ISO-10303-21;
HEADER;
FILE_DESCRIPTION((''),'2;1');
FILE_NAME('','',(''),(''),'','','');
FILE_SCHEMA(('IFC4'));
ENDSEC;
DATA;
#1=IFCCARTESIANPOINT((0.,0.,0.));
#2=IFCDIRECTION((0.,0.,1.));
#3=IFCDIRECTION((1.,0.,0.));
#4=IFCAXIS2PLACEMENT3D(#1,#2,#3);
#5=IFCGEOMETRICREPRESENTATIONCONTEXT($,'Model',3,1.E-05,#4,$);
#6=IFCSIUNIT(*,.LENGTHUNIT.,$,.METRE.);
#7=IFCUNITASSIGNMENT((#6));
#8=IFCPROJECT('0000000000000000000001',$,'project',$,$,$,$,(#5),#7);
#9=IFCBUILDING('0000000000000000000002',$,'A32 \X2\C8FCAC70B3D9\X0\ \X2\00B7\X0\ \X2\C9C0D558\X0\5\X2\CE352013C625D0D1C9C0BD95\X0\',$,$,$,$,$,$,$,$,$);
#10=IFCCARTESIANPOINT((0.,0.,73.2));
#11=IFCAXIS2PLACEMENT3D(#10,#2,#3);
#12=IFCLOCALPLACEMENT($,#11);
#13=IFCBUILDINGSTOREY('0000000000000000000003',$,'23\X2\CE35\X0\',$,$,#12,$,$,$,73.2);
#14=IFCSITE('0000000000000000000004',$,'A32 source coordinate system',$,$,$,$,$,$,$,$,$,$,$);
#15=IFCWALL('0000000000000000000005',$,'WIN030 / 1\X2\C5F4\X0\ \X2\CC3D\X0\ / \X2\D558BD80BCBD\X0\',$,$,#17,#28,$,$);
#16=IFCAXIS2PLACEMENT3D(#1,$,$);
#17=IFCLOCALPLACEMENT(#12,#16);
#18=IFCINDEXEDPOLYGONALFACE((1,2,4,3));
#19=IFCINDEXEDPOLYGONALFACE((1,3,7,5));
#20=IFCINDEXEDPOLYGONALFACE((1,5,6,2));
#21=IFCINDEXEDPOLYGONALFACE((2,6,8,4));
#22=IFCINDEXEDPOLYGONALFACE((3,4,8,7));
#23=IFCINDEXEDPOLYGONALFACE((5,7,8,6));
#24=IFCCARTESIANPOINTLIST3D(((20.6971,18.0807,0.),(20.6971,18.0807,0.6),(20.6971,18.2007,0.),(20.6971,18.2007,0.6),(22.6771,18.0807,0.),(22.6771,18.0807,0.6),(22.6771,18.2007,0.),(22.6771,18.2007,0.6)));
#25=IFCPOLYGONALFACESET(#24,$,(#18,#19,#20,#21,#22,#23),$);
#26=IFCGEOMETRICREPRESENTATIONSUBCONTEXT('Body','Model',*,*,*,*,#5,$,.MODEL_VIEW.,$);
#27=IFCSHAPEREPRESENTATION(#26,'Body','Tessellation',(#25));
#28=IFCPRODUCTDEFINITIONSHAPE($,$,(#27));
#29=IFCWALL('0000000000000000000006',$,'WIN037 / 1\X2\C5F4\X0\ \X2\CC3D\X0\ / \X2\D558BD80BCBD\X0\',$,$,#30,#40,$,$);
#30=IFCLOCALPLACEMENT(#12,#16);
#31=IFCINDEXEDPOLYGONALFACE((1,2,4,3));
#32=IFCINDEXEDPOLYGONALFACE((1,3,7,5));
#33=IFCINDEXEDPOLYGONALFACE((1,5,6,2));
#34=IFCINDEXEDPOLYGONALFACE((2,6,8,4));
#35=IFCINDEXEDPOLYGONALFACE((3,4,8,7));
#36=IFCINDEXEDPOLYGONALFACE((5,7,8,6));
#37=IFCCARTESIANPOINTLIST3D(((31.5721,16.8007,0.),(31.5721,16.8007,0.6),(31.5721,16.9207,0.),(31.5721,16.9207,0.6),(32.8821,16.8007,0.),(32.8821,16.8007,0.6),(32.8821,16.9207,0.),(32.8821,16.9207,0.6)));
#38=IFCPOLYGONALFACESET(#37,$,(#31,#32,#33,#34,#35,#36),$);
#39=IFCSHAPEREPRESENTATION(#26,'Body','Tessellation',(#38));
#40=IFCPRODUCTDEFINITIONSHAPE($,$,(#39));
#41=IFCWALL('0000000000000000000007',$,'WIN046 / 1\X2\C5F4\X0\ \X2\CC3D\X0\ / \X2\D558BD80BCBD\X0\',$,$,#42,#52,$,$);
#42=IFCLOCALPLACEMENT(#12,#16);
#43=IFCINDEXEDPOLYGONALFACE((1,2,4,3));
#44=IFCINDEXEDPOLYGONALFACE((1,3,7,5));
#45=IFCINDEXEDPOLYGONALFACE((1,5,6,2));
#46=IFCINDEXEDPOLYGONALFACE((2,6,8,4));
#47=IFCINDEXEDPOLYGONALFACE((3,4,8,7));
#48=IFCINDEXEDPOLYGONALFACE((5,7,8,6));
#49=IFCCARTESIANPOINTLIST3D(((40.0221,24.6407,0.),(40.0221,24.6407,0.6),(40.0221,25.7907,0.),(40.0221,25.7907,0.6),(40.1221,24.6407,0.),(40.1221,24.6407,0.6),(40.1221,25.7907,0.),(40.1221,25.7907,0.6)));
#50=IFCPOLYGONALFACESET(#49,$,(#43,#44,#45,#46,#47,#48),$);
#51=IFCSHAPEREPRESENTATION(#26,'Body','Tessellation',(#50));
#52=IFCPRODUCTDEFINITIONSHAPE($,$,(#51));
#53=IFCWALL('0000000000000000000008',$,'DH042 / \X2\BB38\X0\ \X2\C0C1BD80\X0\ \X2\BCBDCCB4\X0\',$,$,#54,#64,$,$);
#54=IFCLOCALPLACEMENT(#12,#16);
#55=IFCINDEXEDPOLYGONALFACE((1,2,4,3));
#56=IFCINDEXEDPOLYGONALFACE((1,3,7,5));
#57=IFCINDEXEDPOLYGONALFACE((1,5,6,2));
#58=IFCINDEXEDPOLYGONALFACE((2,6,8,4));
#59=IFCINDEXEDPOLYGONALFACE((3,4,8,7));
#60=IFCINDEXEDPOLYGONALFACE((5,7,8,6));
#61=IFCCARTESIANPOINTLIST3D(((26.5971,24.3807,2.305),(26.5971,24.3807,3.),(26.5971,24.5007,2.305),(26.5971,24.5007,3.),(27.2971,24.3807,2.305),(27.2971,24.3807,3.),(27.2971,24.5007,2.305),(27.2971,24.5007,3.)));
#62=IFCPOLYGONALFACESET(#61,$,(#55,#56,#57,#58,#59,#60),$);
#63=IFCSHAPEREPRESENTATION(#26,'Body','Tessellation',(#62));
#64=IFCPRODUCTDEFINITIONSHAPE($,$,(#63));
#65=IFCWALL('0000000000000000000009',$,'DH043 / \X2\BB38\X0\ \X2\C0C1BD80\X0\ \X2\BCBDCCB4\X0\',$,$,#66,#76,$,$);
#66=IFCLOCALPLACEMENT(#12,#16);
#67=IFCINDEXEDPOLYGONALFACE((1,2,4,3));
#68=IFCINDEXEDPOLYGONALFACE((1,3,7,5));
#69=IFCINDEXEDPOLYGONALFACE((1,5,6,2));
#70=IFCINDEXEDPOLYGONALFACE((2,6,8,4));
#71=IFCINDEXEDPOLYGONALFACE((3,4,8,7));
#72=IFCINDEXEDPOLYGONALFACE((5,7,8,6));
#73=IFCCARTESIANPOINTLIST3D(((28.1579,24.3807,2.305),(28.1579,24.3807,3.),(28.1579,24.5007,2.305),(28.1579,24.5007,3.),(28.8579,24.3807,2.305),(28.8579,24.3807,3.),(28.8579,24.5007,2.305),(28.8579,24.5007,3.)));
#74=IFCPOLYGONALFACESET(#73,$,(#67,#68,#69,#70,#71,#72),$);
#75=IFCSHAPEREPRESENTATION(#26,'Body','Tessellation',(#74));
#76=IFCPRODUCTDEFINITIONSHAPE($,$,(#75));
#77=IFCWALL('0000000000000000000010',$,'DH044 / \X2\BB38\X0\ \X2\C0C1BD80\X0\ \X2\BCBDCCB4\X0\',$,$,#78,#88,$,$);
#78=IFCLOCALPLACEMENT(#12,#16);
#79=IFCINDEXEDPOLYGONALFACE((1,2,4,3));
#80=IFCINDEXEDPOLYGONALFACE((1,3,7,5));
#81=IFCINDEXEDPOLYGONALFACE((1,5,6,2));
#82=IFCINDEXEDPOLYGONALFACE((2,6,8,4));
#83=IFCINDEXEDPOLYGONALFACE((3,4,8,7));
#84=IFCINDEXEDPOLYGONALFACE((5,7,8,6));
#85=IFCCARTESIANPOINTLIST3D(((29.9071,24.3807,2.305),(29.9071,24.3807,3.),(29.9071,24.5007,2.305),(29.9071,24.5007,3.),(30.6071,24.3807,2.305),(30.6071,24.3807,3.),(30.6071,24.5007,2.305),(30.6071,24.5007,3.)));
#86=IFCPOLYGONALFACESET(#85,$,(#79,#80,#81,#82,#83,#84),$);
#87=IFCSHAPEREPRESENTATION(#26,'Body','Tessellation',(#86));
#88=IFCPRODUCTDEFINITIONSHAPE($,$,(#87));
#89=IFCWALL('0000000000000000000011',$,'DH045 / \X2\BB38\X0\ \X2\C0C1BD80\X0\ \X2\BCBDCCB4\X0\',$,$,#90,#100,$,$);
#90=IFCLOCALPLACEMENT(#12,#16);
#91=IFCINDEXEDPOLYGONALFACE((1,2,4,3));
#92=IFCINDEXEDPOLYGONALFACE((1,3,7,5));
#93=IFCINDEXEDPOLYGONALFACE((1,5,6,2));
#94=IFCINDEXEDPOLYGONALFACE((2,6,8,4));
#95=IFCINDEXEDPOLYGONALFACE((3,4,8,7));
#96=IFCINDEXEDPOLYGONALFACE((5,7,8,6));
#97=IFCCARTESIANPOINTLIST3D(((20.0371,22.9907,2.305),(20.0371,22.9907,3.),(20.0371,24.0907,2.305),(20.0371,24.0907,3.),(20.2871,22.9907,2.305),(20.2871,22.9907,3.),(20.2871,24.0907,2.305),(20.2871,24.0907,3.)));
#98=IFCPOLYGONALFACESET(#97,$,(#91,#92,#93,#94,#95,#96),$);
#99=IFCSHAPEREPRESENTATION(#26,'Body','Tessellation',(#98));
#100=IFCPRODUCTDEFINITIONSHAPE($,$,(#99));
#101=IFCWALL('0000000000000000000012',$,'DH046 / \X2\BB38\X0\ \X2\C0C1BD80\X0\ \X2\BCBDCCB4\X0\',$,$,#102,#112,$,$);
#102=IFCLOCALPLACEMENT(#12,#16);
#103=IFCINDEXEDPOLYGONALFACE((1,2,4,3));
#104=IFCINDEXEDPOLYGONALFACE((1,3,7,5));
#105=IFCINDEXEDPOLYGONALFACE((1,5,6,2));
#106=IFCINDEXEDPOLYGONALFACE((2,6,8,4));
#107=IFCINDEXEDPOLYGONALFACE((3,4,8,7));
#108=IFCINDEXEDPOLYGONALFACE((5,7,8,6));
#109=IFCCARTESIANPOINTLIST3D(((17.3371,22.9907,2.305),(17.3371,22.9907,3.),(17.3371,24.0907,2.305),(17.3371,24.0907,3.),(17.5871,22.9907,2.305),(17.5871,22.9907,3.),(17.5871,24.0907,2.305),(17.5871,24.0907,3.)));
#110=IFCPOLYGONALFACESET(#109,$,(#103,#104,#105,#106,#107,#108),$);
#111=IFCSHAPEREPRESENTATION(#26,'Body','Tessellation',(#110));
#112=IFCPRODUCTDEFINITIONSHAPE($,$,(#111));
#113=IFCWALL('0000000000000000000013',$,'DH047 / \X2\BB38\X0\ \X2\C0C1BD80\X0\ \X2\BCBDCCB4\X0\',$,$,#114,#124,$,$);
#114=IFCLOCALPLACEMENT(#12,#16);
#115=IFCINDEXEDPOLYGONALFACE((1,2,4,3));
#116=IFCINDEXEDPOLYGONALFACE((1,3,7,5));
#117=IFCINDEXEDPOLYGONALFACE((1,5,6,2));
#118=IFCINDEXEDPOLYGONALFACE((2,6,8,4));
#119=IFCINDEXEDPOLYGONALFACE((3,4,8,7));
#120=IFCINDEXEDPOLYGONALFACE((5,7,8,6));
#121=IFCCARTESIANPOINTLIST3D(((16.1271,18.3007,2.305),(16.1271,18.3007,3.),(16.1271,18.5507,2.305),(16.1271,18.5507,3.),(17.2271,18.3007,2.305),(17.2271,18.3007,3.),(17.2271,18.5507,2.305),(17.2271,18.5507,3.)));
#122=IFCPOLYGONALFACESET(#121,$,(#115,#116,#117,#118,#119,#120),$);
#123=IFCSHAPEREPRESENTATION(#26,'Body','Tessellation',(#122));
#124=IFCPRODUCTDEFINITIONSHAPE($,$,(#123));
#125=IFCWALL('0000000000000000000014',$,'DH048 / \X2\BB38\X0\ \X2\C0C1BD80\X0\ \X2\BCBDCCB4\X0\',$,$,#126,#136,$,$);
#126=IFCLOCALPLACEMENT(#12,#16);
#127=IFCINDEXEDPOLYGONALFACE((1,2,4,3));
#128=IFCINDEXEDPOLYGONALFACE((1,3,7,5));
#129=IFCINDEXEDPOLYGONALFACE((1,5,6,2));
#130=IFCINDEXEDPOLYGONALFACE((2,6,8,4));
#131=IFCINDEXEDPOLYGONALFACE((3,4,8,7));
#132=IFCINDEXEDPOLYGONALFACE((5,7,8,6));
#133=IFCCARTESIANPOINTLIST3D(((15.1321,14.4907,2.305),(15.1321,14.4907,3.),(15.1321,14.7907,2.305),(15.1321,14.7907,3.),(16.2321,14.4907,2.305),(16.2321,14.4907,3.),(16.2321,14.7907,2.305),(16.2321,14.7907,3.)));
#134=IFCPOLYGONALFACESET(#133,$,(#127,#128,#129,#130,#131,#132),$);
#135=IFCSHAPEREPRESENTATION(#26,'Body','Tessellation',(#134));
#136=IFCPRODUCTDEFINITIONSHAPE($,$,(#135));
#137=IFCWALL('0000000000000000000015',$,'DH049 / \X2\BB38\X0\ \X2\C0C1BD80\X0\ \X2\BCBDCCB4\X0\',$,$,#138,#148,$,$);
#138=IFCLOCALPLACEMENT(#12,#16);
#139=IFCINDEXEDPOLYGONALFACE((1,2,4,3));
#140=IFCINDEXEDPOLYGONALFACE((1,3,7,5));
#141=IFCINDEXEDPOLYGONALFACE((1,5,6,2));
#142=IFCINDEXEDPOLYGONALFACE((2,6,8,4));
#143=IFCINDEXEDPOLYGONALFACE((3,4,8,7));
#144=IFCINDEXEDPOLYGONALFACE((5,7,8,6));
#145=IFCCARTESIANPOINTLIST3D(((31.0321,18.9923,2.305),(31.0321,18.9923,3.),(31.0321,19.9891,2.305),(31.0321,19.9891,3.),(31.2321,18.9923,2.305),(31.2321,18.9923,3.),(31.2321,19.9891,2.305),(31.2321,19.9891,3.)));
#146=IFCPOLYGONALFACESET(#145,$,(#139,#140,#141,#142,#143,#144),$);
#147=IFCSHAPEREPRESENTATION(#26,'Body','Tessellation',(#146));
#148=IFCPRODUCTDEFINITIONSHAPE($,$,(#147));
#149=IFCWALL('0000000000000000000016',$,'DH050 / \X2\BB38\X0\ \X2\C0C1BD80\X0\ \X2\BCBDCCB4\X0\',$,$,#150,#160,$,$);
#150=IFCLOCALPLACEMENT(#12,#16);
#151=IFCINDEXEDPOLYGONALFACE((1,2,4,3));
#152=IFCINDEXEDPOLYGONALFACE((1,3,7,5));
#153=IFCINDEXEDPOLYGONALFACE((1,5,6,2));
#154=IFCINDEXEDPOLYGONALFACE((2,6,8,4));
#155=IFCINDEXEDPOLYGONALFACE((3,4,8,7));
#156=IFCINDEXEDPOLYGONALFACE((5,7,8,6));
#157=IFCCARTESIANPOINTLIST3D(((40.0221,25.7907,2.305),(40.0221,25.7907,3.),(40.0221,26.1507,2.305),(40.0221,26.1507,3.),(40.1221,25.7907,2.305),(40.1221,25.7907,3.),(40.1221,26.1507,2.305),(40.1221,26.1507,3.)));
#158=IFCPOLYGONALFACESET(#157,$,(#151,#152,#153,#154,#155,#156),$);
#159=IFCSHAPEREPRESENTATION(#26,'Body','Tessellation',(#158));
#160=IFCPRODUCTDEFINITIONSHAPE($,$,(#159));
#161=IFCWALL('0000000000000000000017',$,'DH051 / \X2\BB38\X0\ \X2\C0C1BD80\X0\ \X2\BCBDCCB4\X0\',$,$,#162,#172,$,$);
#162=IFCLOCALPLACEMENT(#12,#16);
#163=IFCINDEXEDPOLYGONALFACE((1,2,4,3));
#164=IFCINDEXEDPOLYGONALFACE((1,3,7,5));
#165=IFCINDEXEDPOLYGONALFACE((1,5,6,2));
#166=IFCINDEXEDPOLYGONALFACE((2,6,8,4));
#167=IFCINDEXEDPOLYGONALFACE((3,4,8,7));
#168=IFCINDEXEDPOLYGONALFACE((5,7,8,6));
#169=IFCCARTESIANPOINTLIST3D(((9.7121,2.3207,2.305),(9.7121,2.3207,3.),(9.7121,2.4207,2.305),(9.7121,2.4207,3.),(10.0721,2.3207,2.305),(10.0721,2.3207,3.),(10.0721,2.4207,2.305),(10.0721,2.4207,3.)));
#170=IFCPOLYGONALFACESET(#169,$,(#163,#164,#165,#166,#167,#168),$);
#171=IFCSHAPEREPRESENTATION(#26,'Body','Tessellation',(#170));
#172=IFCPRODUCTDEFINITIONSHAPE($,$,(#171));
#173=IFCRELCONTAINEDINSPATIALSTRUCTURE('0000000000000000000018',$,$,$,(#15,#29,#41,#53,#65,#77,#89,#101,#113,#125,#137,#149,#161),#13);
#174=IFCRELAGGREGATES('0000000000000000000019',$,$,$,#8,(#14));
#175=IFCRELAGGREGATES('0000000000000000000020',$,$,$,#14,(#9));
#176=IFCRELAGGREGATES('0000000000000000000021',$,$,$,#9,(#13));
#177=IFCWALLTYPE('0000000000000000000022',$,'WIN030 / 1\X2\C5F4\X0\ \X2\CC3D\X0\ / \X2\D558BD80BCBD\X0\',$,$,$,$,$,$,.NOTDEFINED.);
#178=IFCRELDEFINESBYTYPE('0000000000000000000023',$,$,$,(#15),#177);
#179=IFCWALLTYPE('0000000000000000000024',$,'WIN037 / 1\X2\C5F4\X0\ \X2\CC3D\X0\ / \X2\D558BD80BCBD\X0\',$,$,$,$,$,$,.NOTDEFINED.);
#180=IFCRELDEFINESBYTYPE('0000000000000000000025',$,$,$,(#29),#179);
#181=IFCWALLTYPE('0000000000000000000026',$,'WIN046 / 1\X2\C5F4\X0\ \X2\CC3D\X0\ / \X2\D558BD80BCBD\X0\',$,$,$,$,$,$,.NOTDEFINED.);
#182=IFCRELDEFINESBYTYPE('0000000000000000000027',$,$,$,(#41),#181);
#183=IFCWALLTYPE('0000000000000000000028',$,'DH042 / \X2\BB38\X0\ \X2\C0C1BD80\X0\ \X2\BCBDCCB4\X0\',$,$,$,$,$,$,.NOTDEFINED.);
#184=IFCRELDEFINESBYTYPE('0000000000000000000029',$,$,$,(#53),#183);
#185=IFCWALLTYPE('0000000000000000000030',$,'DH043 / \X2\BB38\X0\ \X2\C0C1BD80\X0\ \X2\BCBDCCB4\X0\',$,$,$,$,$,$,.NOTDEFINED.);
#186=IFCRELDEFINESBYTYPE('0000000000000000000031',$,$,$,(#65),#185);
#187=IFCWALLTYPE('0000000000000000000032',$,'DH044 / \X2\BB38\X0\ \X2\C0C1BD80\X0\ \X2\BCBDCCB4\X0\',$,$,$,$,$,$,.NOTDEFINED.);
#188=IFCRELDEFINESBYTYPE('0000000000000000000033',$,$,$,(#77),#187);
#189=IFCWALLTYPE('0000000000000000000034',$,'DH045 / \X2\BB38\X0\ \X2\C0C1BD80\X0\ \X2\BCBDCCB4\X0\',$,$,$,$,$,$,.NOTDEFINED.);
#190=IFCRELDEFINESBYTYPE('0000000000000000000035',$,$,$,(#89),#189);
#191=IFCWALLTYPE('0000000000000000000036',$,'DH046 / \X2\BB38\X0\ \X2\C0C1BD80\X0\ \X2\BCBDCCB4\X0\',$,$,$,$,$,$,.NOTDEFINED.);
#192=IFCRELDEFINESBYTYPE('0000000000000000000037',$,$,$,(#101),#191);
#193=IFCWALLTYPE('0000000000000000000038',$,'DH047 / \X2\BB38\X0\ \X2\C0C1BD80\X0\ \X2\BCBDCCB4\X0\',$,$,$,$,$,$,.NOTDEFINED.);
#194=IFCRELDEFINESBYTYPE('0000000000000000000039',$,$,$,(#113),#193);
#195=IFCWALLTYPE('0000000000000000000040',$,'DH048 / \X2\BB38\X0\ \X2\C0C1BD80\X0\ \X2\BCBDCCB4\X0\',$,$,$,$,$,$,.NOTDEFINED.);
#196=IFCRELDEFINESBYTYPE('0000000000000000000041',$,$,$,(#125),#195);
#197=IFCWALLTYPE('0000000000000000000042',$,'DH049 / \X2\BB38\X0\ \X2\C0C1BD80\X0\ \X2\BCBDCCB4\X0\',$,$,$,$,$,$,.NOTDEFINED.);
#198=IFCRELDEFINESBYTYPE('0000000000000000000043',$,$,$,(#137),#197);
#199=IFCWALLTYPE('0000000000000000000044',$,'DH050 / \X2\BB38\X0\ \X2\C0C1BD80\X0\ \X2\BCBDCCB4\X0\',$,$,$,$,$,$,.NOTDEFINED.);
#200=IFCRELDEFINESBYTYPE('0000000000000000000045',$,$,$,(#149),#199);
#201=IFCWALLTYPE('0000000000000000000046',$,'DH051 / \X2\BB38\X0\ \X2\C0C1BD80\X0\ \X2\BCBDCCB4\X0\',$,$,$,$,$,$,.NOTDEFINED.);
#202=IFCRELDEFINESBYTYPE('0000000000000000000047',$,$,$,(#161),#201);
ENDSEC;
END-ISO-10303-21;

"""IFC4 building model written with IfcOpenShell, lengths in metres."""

from ifc_helpers import new_model, si_unit, frame, origin, origin_with_axes, place, context, subcontext, project, spatial, polyline, outline, extrude, source, transform, mapped, type_object, type_shapes, element, save


model = new_model("IFC4")

# Units and contexts
model_context = context("Model", 3, precision=1e-05, world=origin_with_axes())
body_context = subcontext(model_context, "Body", "Model", "MODEL_VIEW")
ifc_project = project(units=[si_unit("LENGTHUNIT", "METRE")], contexts=[model_context])

# Site, building, storey
site = spatial("IfcSite", under=ifc_project, Name="A32 source coordinate system")
building = spatial("IfcBuilding", under=site, Name="A32 주거동 · 지하5층–옥탑지붕")
storey_placement = place(None, frame((0.0, 0.0, 73.2), z_axis=(0.0, 0.0, 1.0), x_axis=(1.0, 0.0, 0.0)))
storey = spatial("IfcBuildingStorey", under=building, at=storey_placement, Name="23층", Elevation=73.2)

# Walls
wall_type_1 = type_object("IfcWallType", Name="WIN030 / 1열 창 / 하부벽", PredefinedType="NOTDEFINED")
shared_shape_1 = source(origin(), body_context, "Body", "SweptSolid", [
    extrude(outline(polyline([(22.6771, 18.2007), (22.6771, 18.0807), (20.6971, 18.0807), (20.6971, 18.2007), (22.6771, 18.2007)])), origin(), (0.0, 0.0, 1.0), 0.6),
])
type_shapes(wall_type_1, [shared_shape_1])
wall_1_placement = place(storey_placement, origin_with_axes())
element("IfcWall", 1, at=wall_1_placement, inside=storey, type_object=wall_type_1, Name="WIN030 / 1열 창 / 하부벽", context=body_context, shape_type="MappedRepresentation", body=[
    mapped(shared_shape_1, transform((0.0, 0.0, 0.0), scale=1.0)),
])
wall_type_2 = type_object("IfcWallType", Name="WIN037 / 1열 창 / 하부벽", PredefinedType="NOTDEFINED")
shared_shape_2 = source(origin(), body_context, "Body", "SweptSolid", [
    extrude(outline(polyline([(32.8821, 16.9207), (32.8821, 16.8007), (31.5721, 16.8007), (31.5721, 16.9207), (32.8821, 16.9207)])), origin(), (0.0, 0.0, 1.0), 0.6),
])
type_shapes(wall_type_2, [shared_shape_2])
wall_2_placement = place(storey_placement, origin_with_axes())
element("IfcWall", 2, at=wall_2_placement, inside=storey, type_object=wall_type_2, Name="WIN037 / 1열 창 / 하부벽", context=body_context, shape_type="MappedRepresentation", body=[
    mapped(shared_shape_2, transform((0.0, 0.0, 0.0), scale=1.0)),
])
wall_type_3 = type_object("IfcWallType", Name="WIN046 / 1열 창 / 하부벽", PredefinedType="NOTDEFINED")
shared_shape_3 = source(origin(), body_context, "Body", "SweptSolid", [
    extrude(outline(polyline([(40.1221, 25.7907), (40.1221, 24.6407), (40.0221, 24.6407), (40.0221, 25.7907), (40.1221, 25.7907)])), origin(), (0.0, 0.0, 1.0), 0.6),
])
type_shapes(wall_type_3, [shared_shape_3])
wall_3_placement = place(storey_placement, origin_with_axes())
element("IfcWall", 3, at=wall_3_placement, inside=storey, type_object=wall_type_3, Name="WIN046 / 1열 창 / 하부벽", context=body_context, shape_type="MappedRepresentation", body=[
    mapped(shared_shape_3, transform((0.0, 0.0, 0.0), scale=1.0)),
])
wall_type_4 = type_object("IfcWallType", Name="DH042 / 문 상부 벽체", PredefinedType="NOTDEFINED")
shared_shape_4 = source(origin(), body_context, "Body", "SweptSolid", [
    extrude(outline(polyline([(27.2971, 24.3807), (26.5971, 24.3807), (26.5971, 24.5007), (27.2971, 24.5007), (27.2971, 24.3807)])), frame((0.0, 0.0, 2.305)), (0.0, 0.0, 1.0), 0.695),
])
type_shapes(wall_type_4, [shared_shape_4])
wall_4_placement = place(storey_placement, origin_with_axes())
element("IfcWall", 4, at=wall_4_placement, inside=storey, type_object=wall_type_4, Name="DH042 / 문 상부 벽체", context=body_context, shape_type="MappedRepresentation", body=[
    mapped(shared_shape_4, transform((0.0, 0.0, 0.0), scale=1.0)),
])
wall_type_5 = type_object("IfcWallType", Name="DH043 / 문 상부 벽체", PredefinedType="NOTDEFINED")
shared_shape_5 = source(origin(), body_context, "Body", "SweptSolid", [
    extrude(outline(polyline([(28.8579, 24.3807), (28.1579, 24.3807), (28.1579, 24.5007), (28.8579, 24.5007), (28.8579, 24.3807)])), frame((0.0, 0.0, 2.305)), (0.0, 0.0, 1.0), 0.695),
])
type_shapes(wall_type_5, [shared_shape_5])
wall_5_placement = place(storey_placement, origin_with_axes())
element("IfcWall", 5, at=wall_5_placement, inside=storey, type_object=wall_type_5, Name="DH043 / 문 상부 벽체", context=body_context, shape_type="MappedRepresentation", body=[
    mapped(shared_shape_5, transform((0.0, 0.0, 0.0), scale=1.0)),
])
wall_type_6 = type_object("IfcWallType", Name="DH044 / 문 상부 벽체", PredefinedType="NOTDEFINED")
shared_shape_6 = source(origin(), body_context, "Body", "SweptSolid", [
    extrude(outline(polyline([(30.6071, 24.3807), (29.9071, 24.3807), (29.9071, 24.5007), (30.6071, 24.5007), (30.6071, 24.3807)])), frame((0.0, 0.0, 2.305)), (0.0, 0.0, 1.0), 0.695),
])
type_shapes(wall_type_6, [shared_shape_6])
wall_6_placement = place(storey_placement, origin_with_axes())
element("IfcWall", 6, at=wall_6_placement, inside=storey, type_object=wall_type_6, Name="DH044 / 문 상부 벽체", context=body_context, shape_type="MappedRepresentation", body=[
    mapped(shared_shape_6, transform((0.0, 0.0, 0.0), scale=1.0)),
])
wall_type_7 = type_object("IfcWallType", Name="DH045 / 문 상부 벽체", PredefinedType="NOTDEFINED")
shared_shape_7 = source(origin(), body_context, "Body", "SweptSolid", [
    extrude(outline(polyline([(20.2871, 22.9907), (20.0371, 22.9907), (20.0371, 24.0907), (20.2871, 24.0907), (20.2871, 22.9907)])), frame((0.0, 0.0, 2.305)), (0.0, 0.0, 1.0), 0.695),
])
type_shapes(wall_type_7, [shared_shape_7])
wall_7_placement = place(storey_placement, origin_with_axes())
element("IfcWall", 7, at=wall_7_placement, inside=storey, type_object=wall_type_7, Name="DH045 / 문 상부 벽체", context=body_context, shape_type="MappedRepresentation", body=[
    mapped(shared_shape_7, transform((0.0, 0.0, 0.0), scale=1.0)),
])
wall_type_8 = type_object("IfcWallType", Name="DH046 / 문 상부 벽체", PredefinedType="NOTDEFINED")
shared_shape_8 = source(origin(), body_context, "Body", "SweptSolid", [
    extrude(outline(polyline([(17.5871, 22.9907), (17.3371, 22.9907), (17.3371, 24.0907), (17.5871, 24.0907), (17.5871, 22.9907)])), frame((0.0, 0.0, 2.305)), (0.0, 0.0, 1.0), 0.695),
])
type_shapes(wall_type_8, [shared_shape_8])
wall_8_placement = place(storey_placement, origin_with_axes())
element("IfcWall", 8, at=wall_8_placement, inside=storey, type_object=wall_type_8, Name="DH046 / 문 상부 벽체", context=body_context, shape_type="MappedRepresentation", body=[
    mapped(shared_shape_8, transform((0.0, 0.0, 0.0), scale=1.0)),
])
wall_type_9 = type_object("IfcWallType", Name="DH047 / 문 상부 벽체", PredefinedType="NOTDEFINED")
shared_shape_9 = source(origin(), body_context, "Body", "SweptSolid", [
    extrude(outline(polyline([(17.2271, 18.3007), (16.1271, 18.3007), (16.1271, 18.5507), (17.2271, 18.5507), (17.2271, 18.3007)])), frame((0.0, 0.0, 2.305)), (0.0, 0.0, 1.0), 0.695),
])
type_shapes(wall_type_9, [shared_shape_9])
wall_9_placement = place(storey_placement, origin_with_axes())
element("IfcWall", 9, at=wall_9_placement, inside=storey, type_object=wall_type_9, Name="DH047 / 문 상부 벽체", context=body_context, shape_type="MappedRepresentation", body=[
    mapped(shared_shape_9, transform((0.0, 0.0, 0.0), scale=1.0)),
])
wall_type_10 = type_object("IfcWallType", Name="DH048 / 문 상부 벽체", PredefinedType="NOTDEFINED")
shared_shape_10 = source(origin(), body_context, "Body", "SweptSolid", [
    extrude(outline(polyline([(15.1321, 14.7907), (16.2321, 14.7907), (16.2321, 14.4907), (15.1321, 14.4907), (15.1321, 14.7907)])), frame((0.0, 0.0, 2.305)), (0.0, 0.0, 1.0), 0.695),
])
type_shapes(wall_type_10, [shared_shape_10])
wall_10_placement = place(storey_placement, origin_with_axes())
element("IfcWall", 10, at=wall_10_placement, inside=storey, type_object=wall_type_10, Name="DH048 / 문 상부 벽체", context=body_context, shape_type="MappedRepresentation", body=[
    mapped(shared_shape_10, transform((0.0, 0.0, 0.0), scale=1.0)),
])
wall_type_11 = type_object("IfcWallType", Name="DH049 / 문 상부 벽체", PredefinedType="NOTDEFINED")
shared_shape_11 = source(origin(), body_context, "Body", "SweptSolid", [
    extrude(outline(polyline([(31.2321, 18.9923), (31.0321, 18.9923), (31.0321, 19.9891), (31.2321, 19.9891), (31.2321, 18.9923)])), frame((0.0, 0.0, 2.305)), (0.0, 0.0, 1.0), 0.695),
])
type_shapes(wall_type_11, [shared_shape_11])
wall_11_placement = place(storey_placement, origin_with_axes())
element("IfcWall", 11, at=wall_11_placement, inside=storey, type_object=wall_type_11, Name="DH049 / 문 상부 벽체", context=body_context, shape_type="MappedRepresentation", body=[
    mapped(shared_shape_11, transform((0.0, 0.0, 0.0), scale=1.0)),
])
wall_type_12 = type_object("IfcWallType", Name="DH050 / 문 상부 벽체", PredefinedType="NOTDEFINED")
shared_shape_12 = source(origin(), body_context, "Body", "SweptSolid", [
    extrude(outline(polyline([(40.0221, 25.7907), (40.0221, 26.1507), (40.1221, 26.1507), (40.1221, 25.7907), (40.0221, 25.7907)])), frame((0.0, 0.0, 2.305)), (0.0, 0.0, 1.0), 0.695),
])
type_shapes(wall_type_12, [shared_shape_12])
wall_12_placement = place(storey_placement, origin_with_axes())
element("IfcWall", 12, at=wall_12_placement, inside=storey, type_object=wall_type_12, Name="DH050 / 문 상부 벽체", context=body_context, shape_type="MappedRepresentation", body=[
    mapped(shared_shape_12, transform((0.0, 0.0, 0.0), scale=1.0)),
])
wall_type_13 = type_object("IfcWallType", Name="DH051 / 문 상부 벽체", PredefinedType="NOTDEFINED")
shared_shape_13 = source(origin(), body_context, "Body", "SweptSolid", [
    extrude(outline(polyline([(10.0721, 2.3207), (9.7121, 2.3207), (9.7121, 2.4207), (10.0721, 2.4207), (10.0721, 2.3207)])), frame((0.0, 0.0, 2.305)), (0.0, 0.0, 1.0), 0.695),
])
type_shapes(wall_type_13, [shared_shape_13])
wall_13_placement = place(storey_placement, origin_with_axes())
element("IfcWall", 13, at=wall_13_placement, inside=storey, type_object=wall_type_13, Name="DH051 / 문 상부 벽체", context=body_context, shape_type="MappedRepresentation", body=[
    mapped(shared_shape_13, transform((0.0, 0.0, 0.0), scale=1.0)),
])

save(model, "model.ifc")
